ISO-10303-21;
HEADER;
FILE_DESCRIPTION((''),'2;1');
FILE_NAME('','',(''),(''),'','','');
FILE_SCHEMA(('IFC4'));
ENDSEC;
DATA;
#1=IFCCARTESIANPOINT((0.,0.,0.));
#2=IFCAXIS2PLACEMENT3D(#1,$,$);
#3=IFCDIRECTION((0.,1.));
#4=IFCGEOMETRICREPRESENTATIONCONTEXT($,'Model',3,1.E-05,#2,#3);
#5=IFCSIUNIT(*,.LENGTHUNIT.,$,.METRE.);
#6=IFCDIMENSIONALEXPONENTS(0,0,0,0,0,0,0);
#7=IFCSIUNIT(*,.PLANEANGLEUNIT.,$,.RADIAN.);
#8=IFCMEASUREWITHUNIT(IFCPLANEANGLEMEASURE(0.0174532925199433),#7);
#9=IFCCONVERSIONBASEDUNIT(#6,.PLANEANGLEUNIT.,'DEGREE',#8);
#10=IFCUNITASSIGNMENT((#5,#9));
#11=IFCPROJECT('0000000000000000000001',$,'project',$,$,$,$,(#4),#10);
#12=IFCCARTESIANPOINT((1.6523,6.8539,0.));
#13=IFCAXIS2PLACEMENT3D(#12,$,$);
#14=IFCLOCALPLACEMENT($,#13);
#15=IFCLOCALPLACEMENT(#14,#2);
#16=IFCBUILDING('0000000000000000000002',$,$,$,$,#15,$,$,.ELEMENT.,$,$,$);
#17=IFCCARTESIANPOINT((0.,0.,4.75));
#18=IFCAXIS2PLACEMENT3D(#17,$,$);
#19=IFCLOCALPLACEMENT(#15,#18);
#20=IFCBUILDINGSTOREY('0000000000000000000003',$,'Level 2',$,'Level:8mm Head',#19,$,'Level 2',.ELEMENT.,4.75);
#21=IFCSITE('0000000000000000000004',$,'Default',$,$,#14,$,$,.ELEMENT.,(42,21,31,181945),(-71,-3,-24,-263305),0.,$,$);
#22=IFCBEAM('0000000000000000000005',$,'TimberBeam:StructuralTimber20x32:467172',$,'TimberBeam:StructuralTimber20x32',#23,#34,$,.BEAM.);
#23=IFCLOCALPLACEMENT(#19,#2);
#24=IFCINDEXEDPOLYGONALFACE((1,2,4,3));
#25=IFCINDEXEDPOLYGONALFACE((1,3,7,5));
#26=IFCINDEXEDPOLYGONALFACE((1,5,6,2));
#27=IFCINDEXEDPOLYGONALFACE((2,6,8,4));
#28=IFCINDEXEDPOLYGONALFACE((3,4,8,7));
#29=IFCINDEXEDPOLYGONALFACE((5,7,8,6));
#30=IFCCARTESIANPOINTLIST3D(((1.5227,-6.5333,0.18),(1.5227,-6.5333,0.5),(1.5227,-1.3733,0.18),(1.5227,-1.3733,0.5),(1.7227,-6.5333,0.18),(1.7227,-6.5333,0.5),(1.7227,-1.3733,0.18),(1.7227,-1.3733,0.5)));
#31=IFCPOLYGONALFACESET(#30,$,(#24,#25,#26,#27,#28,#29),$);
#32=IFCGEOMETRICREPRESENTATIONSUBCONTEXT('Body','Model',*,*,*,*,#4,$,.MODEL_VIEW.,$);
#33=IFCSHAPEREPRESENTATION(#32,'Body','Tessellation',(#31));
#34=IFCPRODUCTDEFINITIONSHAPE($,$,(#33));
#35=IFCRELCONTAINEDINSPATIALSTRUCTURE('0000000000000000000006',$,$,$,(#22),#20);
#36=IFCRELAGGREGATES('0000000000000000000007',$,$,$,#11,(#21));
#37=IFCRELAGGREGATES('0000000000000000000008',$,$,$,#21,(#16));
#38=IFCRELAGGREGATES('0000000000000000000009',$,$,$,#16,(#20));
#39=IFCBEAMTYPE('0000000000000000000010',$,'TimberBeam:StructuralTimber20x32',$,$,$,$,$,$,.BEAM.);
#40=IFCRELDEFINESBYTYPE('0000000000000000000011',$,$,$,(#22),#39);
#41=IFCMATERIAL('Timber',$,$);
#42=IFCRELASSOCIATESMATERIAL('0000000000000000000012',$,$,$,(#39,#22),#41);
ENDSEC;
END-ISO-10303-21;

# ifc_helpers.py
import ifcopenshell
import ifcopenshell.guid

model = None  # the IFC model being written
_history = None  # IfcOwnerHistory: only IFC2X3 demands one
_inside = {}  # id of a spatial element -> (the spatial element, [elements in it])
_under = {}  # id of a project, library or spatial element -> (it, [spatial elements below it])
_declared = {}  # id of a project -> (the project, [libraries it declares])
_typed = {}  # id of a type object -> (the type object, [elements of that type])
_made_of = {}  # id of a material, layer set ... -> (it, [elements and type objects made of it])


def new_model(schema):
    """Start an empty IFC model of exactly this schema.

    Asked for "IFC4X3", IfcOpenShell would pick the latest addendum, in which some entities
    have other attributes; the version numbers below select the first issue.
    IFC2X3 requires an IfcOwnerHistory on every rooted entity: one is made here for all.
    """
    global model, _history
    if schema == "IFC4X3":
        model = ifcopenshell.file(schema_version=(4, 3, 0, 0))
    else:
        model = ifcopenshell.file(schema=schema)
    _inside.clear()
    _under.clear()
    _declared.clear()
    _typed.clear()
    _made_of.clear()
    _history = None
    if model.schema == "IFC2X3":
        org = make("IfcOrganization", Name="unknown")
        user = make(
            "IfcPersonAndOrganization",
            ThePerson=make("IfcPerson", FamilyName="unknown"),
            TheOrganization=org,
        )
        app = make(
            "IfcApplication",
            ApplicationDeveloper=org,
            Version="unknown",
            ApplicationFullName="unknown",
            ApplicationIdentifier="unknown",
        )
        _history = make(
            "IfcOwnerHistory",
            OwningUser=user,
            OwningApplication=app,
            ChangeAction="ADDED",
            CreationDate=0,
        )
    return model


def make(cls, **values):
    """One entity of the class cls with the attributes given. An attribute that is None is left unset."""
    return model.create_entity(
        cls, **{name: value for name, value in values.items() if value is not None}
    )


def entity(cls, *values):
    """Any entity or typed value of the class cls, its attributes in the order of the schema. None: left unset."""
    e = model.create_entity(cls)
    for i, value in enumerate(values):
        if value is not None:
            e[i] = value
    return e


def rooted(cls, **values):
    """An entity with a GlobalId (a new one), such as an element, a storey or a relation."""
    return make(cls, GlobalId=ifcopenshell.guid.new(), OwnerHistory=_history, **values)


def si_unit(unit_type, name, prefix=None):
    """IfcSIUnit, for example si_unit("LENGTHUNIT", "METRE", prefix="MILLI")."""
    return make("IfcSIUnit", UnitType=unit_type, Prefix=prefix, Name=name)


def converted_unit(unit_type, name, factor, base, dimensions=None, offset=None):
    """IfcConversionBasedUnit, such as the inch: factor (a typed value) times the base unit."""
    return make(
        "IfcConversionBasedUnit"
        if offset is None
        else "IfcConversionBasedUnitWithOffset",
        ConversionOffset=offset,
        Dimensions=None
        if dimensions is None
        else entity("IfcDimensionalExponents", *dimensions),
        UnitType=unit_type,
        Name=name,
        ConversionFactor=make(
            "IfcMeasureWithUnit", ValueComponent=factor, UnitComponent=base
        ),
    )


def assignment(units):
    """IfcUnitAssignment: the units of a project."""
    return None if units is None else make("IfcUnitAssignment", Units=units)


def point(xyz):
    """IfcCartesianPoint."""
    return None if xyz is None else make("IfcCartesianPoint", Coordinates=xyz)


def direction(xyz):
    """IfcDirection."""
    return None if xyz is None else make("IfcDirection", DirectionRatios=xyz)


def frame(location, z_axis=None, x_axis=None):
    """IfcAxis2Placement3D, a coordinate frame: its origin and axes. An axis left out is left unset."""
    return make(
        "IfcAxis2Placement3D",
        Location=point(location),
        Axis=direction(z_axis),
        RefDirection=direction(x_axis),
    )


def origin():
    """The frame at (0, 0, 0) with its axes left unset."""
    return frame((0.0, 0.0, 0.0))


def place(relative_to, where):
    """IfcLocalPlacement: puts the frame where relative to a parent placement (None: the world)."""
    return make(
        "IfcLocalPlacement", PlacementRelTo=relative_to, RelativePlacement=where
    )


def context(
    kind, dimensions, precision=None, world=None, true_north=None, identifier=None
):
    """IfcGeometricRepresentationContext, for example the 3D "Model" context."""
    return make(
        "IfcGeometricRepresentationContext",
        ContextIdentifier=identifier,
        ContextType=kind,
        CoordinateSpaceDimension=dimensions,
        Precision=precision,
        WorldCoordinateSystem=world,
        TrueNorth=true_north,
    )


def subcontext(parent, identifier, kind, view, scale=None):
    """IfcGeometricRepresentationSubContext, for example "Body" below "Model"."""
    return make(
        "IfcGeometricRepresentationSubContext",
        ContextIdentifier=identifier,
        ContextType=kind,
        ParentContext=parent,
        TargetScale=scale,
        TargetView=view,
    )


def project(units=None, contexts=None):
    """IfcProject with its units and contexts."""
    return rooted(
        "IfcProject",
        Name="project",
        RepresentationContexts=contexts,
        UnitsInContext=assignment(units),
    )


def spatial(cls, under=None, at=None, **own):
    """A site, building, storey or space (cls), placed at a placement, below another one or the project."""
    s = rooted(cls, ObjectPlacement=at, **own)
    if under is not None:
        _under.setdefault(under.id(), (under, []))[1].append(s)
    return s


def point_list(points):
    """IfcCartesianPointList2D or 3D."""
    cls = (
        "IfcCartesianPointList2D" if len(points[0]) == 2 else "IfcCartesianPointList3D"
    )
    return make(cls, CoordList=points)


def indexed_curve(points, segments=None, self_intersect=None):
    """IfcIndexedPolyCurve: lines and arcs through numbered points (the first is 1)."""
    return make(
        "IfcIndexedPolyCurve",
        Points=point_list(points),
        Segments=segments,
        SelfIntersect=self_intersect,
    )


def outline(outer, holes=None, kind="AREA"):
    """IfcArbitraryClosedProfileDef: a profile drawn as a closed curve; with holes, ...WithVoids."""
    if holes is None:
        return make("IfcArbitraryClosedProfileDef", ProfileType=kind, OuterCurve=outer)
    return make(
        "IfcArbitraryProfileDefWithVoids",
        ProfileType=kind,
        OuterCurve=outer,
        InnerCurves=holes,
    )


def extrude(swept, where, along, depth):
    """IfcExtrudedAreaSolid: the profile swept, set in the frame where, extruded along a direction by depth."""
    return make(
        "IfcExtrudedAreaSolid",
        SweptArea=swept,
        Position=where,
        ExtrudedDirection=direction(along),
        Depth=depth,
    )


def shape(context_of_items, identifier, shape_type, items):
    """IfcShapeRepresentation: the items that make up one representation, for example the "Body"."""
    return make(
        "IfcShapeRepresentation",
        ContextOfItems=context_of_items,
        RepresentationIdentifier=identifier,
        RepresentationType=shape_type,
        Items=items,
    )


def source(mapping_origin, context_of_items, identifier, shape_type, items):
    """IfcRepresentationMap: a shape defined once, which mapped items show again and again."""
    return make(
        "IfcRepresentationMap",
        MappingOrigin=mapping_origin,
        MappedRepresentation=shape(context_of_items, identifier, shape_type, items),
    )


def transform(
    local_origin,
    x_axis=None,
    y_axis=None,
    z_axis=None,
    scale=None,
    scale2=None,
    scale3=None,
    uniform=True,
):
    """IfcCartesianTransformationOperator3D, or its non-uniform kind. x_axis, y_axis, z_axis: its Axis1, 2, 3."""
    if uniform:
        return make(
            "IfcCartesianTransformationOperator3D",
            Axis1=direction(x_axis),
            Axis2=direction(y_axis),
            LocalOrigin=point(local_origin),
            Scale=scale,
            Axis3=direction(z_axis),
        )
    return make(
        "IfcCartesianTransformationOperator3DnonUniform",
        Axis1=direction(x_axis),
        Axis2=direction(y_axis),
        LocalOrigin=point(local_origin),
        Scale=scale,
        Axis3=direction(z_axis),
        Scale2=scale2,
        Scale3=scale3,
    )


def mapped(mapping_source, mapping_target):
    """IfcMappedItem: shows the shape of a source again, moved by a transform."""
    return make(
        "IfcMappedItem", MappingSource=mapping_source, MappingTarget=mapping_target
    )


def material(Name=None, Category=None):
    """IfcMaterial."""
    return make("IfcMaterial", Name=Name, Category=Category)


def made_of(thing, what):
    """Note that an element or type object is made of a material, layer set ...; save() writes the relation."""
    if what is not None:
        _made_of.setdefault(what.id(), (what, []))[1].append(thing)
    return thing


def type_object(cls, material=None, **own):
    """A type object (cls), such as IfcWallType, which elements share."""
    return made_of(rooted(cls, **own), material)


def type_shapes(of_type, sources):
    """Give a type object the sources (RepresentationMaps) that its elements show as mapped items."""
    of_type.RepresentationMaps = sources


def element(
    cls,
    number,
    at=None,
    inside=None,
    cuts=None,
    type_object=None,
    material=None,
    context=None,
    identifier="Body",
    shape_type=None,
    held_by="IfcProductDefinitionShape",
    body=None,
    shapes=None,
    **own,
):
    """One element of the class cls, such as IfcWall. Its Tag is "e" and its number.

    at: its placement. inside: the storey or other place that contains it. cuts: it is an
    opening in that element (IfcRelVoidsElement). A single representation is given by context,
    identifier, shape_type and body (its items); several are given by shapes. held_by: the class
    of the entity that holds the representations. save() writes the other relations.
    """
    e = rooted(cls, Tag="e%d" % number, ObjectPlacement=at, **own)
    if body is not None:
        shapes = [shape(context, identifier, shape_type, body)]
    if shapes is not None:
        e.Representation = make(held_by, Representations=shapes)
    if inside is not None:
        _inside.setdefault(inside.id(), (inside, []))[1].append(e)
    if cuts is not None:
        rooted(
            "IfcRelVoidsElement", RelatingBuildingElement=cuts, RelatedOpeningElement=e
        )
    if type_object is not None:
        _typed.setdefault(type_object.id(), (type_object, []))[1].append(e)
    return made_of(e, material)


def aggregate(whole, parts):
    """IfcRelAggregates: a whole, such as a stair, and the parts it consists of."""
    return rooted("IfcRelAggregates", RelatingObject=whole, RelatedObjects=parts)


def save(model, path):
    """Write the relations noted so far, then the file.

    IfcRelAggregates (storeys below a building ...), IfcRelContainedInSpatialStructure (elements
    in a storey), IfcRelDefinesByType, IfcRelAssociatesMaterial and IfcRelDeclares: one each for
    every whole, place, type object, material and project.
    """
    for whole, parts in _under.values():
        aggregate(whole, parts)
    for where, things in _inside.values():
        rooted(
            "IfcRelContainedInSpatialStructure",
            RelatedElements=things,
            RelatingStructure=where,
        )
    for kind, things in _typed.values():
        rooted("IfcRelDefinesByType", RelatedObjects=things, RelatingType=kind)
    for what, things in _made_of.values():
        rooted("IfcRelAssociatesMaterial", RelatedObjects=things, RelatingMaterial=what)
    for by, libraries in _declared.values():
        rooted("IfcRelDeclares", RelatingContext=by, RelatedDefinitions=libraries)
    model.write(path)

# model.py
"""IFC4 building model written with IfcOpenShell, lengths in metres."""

from ifc_helpers import new_model, entity, si_unit, converted_unit, direction, frame, origin, place, context, subcontext, project, spatial, indexed_curve, outline, extrude, source, transform, mapped, material, type_object, type_shapes, element, save


model = new_model("IFC4")

# Units and contexts
model_context = context("Model", 3, precision=1e-05, world=origin(), true_north=direction((0.0, 1.0)))
body_context = subcontext(model_context, "Body", "Model", "MODEL_VIEW")
ifc_project = project(units=[si_unit("LENGTHUNIT", "METRE"), converted_unit("PLANEANGLEUNIT", "DEGREE", entity("IfcPlaneAngleMeasure", 0.0174532925199433), si_unit("PLANEANGLEUNIT", "RADIAN"), dimensions=[0, 0, 0, 0, 0, 0, 0])], contexts=[model_context])

# Site, building, storey
site_placement = place(None, frame((1.6523, 6.8539, 0.0)))
site = spatial("IfcSite", under=ifc_project, at=site_placement, Name="Default", CompositionType="ELEMENT", RefLatitude=(42, 21, 31, 181945), RefLongitude=(-71, -3, -24, -263305), RefElevation=0.0)
building_placement = place(site_placement, origin())
building = spatial("IfcBuilding", under=site, at=building_placement, CompositionType="ELEMENT")
storey_placement = place(building_placement, frame((0.0, 0.0, 4.75)))
storey = spatial("IfcBuildingStorey", under=building, at=storey_placement, Name="Level 2", ObjectType="Level:8mm Head", LongName="Level 2", CompositionType="ELEMENT", Elevation=4.75)

# Beam
ifc_material = material(Name="Timber")
beam_type = type_object("IfcBeamType", Name="TimberBeam:StructuralTimber20x32", PredefinedType="BEAM", material=ifc_material)
shared_shape = source(origin(), body_context, "Body", "SweptSolid", [
    extrude(outline(indexed_curve([(-2.58, -0.1), (2.58, -0.1), (2.58, 0.1), (-2.58, 0.1), (-2.58, -0.1)], self_intersect=False)), frame((0.0, 0.0, -0.16), z_axis=(0.0, 0.0, 1.0), x_axis=(-1.0, 0.0, 0.0)), (0.0, 0.0, 1.0), 0.32),
])
type_shapes(beam_type, [shared_shape])
beam_placement = place(storey_placement, frame((1.6227, -3.9533, 0.34), z_axis=(0.0, 0.0, 1.0), x_axis=(0.0, -1.0, 0.0)))
element("IfcBeam", 1, at=beam_placement, inside=storey, type_object=beam_type, material=ifc_material, Name="TimberBeam:StructuralTimber20x32:467172", ObjectType="TimberBeam:StructuralTimber20x32", PredefinedType="BEAM", context=body_context, shape_type="MappedRepresentation", body=[
    mapped(shared_shape, transform((0.0, 0.0, 0.0), scale=1.0)),
])

save(model, "model.ifc")
